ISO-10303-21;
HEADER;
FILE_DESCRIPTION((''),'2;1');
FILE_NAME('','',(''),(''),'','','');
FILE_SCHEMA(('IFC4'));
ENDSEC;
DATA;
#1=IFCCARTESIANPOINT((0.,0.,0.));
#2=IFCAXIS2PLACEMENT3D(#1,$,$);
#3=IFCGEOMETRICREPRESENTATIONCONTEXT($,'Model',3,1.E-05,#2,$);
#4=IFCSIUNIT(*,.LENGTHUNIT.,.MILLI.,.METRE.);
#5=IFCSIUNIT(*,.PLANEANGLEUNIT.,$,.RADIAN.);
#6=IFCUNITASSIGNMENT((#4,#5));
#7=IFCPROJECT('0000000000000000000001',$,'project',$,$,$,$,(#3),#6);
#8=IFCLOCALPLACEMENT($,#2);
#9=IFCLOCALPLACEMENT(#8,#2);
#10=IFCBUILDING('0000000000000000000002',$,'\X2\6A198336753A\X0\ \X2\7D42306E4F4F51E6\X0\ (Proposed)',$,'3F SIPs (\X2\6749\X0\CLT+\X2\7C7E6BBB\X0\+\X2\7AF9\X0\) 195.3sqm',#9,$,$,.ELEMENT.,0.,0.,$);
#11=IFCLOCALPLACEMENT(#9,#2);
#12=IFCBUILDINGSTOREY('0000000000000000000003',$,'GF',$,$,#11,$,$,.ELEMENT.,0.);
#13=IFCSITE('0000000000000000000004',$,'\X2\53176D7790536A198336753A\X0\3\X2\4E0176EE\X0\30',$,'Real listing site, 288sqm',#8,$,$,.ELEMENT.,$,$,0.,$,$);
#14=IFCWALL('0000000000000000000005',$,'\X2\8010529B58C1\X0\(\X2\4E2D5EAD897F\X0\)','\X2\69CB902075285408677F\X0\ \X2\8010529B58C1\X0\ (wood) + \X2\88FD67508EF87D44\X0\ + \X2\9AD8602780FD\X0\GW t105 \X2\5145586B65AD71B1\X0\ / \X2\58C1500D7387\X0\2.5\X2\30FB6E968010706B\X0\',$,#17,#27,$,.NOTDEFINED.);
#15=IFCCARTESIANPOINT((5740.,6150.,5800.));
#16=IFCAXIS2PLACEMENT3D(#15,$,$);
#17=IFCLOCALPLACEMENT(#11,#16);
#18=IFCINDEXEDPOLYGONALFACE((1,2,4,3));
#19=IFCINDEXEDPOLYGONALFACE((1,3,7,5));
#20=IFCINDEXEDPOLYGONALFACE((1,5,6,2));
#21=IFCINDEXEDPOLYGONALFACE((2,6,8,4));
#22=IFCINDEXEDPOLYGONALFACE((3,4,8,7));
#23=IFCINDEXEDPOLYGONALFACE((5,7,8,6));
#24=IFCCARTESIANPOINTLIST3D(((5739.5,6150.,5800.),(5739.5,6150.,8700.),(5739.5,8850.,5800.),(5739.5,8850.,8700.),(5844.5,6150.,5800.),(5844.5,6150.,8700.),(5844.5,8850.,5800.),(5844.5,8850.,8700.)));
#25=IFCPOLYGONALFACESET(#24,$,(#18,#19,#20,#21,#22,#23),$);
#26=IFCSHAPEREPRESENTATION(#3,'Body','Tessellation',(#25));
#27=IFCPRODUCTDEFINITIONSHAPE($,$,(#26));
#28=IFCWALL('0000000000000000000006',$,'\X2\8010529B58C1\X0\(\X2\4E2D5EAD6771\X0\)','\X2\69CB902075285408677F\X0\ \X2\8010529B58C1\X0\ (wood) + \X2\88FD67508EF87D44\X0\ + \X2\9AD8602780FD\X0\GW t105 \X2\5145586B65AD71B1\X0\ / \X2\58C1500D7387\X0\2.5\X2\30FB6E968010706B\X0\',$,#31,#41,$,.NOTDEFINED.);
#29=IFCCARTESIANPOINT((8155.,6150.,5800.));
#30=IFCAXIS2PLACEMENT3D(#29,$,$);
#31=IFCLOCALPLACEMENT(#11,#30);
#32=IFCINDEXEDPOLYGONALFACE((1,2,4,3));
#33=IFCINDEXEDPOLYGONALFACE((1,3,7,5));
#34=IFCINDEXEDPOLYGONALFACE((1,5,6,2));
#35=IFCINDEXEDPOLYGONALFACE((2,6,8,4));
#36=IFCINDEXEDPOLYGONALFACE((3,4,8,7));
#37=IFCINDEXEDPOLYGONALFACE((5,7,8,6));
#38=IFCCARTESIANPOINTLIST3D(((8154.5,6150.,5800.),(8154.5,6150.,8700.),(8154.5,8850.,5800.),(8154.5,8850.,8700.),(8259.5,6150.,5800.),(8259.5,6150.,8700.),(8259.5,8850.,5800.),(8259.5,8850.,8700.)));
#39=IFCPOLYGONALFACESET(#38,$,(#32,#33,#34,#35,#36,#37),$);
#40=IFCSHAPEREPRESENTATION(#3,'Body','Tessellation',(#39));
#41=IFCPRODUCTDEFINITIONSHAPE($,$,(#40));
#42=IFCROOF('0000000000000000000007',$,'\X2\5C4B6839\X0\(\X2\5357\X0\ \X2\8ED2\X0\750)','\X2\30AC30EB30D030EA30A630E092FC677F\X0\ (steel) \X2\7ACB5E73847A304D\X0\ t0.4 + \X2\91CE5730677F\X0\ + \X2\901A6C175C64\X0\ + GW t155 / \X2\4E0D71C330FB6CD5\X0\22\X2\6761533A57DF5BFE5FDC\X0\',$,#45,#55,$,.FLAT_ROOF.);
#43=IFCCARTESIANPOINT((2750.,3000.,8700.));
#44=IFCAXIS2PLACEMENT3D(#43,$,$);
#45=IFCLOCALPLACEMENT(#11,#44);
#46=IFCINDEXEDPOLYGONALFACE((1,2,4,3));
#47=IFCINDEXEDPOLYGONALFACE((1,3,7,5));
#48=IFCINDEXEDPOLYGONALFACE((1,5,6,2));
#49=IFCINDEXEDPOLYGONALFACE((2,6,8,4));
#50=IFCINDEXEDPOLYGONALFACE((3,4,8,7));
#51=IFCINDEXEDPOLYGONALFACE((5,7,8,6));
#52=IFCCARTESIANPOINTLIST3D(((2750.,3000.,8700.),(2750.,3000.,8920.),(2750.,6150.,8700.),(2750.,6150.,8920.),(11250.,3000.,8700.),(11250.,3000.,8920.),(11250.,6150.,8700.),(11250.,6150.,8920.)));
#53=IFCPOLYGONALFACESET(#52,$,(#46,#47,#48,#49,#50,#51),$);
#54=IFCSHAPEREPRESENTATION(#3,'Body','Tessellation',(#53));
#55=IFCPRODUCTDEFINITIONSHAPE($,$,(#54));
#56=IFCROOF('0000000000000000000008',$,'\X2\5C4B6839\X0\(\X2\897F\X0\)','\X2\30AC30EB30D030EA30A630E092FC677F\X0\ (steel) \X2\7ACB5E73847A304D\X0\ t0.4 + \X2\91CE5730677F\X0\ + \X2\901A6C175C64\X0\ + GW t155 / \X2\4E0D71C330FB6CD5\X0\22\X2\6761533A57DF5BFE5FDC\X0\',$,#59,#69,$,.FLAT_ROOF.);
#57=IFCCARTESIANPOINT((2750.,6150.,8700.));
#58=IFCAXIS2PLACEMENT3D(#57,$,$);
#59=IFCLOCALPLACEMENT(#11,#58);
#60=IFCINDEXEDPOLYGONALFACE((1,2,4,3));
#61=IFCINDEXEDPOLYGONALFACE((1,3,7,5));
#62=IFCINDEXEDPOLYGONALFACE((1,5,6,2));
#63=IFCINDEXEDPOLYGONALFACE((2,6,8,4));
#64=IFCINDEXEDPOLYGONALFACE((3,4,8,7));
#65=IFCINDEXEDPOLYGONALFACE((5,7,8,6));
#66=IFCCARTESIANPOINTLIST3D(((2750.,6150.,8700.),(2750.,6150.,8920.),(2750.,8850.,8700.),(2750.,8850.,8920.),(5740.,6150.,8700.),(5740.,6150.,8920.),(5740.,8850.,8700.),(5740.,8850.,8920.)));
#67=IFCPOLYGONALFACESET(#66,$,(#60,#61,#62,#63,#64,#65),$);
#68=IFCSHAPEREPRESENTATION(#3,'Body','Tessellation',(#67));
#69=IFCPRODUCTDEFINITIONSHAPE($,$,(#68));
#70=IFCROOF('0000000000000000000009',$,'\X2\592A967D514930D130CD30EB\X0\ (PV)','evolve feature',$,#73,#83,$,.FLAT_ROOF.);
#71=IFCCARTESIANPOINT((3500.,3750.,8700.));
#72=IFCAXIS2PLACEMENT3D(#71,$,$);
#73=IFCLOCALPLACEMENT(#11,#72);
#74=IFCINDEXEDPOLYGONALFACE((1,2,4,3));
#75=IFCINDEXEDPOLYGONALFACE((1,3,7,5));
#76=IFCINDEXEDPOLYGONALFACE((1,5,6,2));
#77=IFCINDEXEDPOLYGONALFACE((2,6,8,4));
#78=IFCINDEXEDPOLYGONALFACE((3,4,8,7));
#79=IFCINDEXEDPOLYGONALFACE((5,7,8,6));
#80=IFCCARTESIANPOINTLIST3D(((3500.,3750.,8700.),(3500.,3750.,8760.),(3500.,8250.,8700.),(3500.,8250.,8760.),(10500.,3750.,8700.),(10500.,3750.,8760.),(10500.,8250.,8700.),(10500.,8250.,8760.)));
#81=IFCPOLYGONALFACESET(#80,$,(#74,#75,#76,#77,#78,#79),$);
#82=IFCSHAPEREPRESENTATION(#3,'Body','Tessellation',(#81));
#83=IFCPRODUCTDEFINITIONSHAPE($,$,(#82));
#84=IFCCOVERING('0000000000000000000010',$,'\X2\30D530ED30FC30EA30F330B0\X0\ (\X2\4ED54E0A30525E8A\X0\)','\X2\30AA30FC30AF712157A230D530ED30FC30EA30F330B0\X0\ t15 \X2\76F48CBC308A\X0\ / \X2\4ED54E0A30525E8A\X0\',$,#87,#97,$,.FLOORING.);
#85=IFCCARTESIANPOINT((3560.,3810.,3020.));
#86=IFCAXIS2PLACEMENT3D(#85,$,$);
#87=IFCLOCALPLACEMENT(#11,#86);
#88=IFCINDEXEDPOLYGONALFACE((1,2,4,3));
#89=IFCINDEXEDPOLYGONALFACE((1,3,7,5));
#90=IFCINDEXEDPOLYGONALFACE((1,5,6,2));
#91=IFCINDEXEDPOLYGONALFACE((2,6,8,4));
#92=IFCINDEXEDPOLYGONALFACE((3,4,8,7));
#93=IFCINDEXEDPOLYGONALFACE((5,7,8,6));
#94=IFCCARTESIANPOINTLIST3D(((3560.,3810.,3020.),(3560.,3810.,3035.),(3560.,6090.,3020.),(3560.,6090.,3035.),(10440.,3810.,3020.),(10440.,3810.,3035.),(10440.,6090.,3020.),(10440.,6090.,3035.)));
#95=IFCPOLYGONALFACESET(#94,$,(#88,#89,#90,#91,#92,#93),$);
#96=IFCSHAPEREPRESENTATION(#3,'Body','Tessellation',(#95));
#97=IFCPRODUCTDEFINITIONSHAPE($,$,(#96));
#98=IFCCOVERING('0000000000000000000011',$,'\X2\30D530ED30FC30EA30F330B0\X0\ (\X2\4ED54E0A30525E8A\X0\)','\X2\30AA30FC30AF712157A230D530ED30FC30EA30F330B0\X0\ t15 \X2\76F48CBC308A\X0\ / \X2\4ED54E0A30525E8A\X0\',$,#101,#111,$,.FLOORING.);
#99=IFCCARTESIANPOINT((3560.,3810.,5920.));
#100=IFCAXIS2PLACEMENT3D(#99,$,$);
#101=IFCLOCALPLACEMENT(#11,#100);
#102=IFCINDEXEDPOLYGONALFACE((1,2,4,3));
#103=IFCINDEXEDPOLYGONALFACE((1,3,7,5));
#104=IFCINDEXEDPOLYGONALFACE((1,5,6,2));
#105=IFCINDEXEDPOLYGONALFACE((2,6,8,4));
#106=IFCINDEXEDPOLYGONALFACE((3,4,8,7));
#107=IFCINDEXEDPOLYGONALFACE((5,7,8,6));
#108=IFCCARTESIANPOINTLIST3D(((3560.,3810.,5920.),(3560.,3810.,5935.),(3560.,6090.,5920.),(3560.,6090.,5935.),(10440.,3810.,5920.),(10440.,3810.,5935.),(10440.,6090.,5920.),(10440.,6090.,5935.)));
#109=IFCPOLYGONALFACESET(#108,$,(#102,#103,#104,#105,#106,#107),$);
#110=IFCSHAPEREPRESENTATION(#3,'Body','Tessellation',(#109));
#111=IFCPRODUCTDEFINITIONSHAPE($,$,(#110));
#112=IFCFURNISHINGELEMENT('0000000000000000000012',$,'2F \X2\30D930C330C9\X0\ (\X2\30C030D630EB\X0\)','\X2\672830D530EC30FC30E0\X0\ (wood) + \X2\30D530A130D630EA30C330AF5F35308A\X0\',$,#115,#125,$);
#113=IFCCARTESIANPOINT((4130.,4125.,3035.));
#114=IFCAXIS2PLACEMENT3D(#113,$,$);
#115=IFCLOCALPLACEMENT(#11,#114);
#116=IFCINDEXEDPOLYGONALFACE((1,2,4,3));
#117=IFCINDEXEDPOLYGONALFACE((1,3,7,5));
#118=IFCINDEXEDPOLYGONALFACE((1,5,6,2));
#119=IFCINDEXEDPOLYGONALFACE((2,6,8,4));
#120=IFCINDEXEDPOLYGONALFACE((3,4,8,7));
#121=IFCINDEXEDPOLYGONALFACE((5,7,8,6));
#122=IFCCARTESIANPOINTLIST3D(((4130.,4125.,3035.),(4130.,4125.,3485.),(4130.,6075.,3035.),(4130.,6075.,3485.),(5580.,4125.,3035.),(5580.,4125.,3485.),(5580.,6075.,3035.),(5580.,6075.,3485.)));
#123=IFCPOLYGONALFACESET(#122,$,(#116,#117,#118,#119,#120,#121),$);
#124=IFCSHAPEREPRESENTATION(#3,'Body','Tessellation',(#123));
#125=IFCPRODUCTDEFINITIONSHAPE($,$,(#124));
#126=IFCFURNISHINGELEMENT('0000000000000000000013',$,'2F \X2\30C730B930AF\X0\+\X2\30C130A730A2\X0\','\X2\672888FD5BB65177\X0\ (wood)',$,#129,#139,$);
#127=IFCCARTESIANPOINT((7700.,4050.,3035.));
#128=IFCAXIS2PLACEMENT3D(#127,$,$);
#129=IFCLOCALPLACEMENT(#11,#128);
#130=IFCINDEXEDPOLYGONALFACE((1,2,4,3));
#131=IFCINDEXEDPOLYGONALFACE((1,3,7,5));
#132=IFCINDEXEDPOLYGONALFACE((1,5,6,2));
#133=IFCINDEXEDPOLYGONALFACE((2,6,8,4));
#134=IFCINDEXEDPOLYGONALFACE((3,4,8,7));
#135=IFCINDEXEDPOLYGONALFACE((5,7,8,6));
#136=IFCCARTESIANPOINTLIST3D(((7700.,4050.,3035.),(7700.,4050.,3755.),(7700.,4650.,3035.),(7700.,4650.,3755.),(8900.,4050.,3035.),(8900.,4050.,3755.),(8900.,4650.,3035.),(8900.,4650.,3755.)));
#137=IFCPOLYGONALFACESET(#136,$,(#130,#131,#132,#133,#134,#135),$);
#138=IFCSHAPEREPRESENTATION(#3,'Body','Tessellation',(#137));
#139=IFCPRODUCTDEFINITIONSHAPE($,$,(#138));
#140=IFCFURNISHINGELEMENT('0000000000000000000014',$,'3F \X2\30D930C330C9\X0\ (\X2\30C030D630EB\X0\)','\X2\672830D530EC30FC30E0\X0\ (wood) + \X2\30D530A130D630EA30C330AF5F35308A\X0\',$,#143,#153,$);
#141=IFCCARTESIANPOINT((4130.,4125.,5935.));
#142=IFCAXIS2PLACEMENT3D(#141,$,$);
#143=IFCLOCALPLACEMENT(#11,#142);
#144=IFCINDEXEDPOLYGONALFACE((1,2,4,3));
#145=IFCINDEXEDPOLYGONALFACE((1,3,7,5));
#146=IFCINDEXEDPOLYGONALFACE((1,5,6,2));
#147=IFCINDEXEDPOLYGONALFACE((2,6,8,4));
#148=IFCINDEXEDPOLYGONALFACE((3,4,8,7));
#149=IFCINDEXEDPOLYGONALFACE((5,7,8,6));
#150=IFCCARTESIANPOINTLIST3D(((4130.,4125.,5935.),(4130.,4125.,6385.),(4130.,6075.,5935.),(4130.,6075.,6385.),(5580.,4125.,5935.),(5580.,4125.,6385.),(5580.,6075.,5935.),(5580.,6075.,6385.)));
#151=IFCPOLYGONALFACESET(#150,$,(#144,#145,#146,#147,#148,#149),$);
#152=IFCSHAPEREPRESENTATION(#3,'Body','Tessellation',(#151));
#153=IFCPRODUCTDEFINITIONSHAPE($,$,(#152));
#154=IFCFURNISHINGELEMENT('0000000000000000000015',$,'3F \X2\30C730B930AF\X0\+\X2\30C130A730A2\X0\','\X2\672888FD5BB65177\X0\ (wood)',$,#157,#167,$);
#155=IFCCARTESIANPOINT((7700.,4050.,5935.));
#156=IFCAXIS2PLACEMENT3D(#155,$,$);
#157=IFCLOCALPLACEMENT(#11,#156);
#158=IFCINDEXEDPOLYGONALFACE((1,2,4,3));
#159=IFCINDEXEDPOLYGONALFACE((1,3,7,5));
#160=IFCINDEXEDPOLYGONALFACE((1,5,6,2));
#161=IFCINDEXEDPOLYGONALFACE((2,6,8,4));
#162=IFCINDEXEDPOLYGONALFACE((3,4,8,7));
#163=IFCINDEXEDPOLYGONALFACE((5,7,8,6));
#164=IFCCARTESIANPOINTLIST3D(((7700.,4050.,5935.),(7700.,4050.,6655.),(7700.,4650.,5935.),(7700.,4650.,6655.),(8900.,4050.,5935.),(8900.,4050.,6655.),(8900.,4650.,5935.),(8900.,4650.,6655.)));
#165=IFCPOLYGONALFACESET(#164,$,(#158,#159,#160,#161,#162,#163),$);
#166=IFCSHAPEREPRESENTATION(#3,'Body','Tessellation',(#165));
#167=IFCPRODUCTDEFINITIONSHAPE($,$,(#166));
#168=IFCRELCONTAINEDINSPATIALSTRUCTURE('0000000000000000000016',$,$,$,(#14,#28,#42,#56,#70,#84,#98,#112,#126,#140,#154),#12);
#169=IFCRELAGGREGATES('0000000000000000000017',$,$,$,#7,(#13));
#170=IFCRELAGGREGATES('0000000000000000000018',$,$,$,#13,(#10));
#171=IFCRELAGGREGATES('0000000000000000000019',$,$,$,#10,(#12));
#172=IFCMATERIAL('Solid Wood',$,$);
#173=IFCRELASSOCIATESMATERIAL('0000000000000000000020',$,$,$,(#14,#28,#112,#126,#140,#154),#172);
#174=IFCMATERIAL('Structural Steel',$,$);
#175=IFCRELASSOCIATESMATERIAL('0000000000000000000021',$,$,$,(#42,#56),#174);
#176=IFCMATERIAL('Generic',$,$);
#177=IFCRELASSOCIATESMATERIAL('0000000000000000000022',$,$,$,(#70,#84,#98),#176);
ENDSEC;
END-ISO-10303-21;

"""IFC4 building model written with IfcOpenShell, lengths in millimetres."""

from ifc_helpers import new_model, si_unit, frame, frame_2d, origin, place, context, project, spatial, rectangle, extrude, material, element, save


model = new_model("IFC4")

# Units and contexts
model_context = context("Model", 3, precision=1e-05, world=origin())
ifc_project = project(units=[si_unit("LENGTHUNIT", "METRE", prefix="MILLI"), si_unit("PLANEANGLEUNIT", "RADIAN")], contexts=[model_context])

# Site, building, storey
site_placement = place(None, origin())
site = spatial("IfcSite", under=ifc_project, at=site_placement, Name="北海道標茶町3丁目30", ObjectType="Real listing site, 288sqm", CompositionType="ELEMENT", RefElevation=0.0)
building_placement = place(site_placement, origin())
building = spatial("IfcBuilding", under=site, at=building_placement, Name="標茶町 終の住処 (Proposed)", ObjectType="3F SIPs (杉CLT+籾殻+竹) 195.3sqm", CompositionType="ELEMENT", ElevationOfRefHeight=0.0, ElevationOfTerrain=0.0)
storey_placement = place(building_placement, origin())
storey = spatial("IfcBuildingStorey", under=building, at=storey_placement, Name="GF", CompositionType="ELEMENT", Elevation=0.0)

# Shared definitions
ifc_material_1 = material(Name="Solid Wood")

# Walls
wall_1_placement = place(storey_placement, frame((5740.0, 6150.0, 5800.0)))
element("IfcWall", 1, at=wall_1_placement, inside=storey, material=ifc_material_1, Name="耐力壁(中庭西)", Description="構造用合板 耐力壁 (wood) + 製材軸組 + 高性能GW t105 充填断熱 / 壁倍率2.5・準耐火", PredefinedType="NOTDEFINED", context=model_context, shape_type="SweptSolid", body=[
    extrude(rectangle(XDim=105.0, YDim=2700.0, at=frame_2d((52.0, 1350.0))), frame((5740.0, 6150.0, 5800.0)), (0.0, 0.0, 1.0), 2900.0),
])
wall_2_placement = place(storey_placement, frame((8155.0, 6150.0, 5800.0)))
element("IfcWall", 2, at=wall_2_placement, inside=storey, material=ifc_material_1, Name="耐力壁(中庭東)", Description="構造用合板 耐力壁 (wood) + 製材軸組 + 高性能GW t105 充填断熱 / 壁倍率2.5・準耐火", PredefinedType="NOTDEFINED", context=model_context, shape_type="SweptSolid", body=[
    extrude(rectangle(XDim=105.0, YDim=2700.0, at=frame_2d((52.0, 1350.0))), frame((8155.0, 6150.0, 5800.0)), (0.0, 0.0, 1.0), 2900.0),
])

# Roofs
ifc_material_2 = material(Name="Structural Steel")
roof_1_placement = place(storey_placement, frame((2750.0, 3000.0, 8700.0)))
element("IfcRoof", 3, at=roof_1_placement, inside=storey, material=ifc_material_2, Name="屋根(南 軒750)", Description="ガルバリウム鋼板 (steel) 立平葺き t0.4 + 野地板 + 通気層 + GW t155 / 不燃・法22条区域対応", PredefinedType="FLAT_ROOF", context=model_context, shape_type="SweptSolid", body=[
    extrude(rectangle(XDim=8500.0, YDim=3150.0, at=frame_2d((4250.0, 1575.0))), frame((2750.0, 3000.0, 8700.0)), (0.0, 0.0, 1.0), 220.0),
])
roof_2_placement = place(storey_placement, frame((2750.0, 6150.0, 8700.0)))
element("IfcRoof", 4, at=roof_2_placement, inside=storey, material=ifc_material_2, Name="屋根(西)", Description="ガルバリウム鋼板 (steel) 立平葺き t0.4 + 野地板 + 通気層 + GW t155 / 不燃・法22条区域対応", PredefinedType="FLAT_ROOF", context=model_context, shape_type="SweptSolid", body=[
    extrude(rectangle(XDim=2990.0, YDim=2700.0, at=frame_2d((1495.0, 1350.0))), frame((2750.0, 6150.0, 8700.0)), (0.0, 0.0, 1.0), 220.0),
])
ifc_material_3 = material(Name="Generic")
roof_3_placement = place(storey_placement, frame((3500.0, 3750.0, 8700.0)))
element("IfcRoof", 5, at=roof_3_placement, inside=storey, material=ifc_material_3, Name="太陽光パネル (PV)", Description="evolve feature", PredefinedType="FLAT_ROOF", context=model_context, shape_type="SweptSolid", body=[
    extrude(rectangle(XDim=7000.0, YDim=4500.0, at=frame_2d((3500.0, 2250.0))), frame((3500.0, 3750.0, 8700.0)), (0.0, 0.0, 1.0), 60.0),
])

# Coverings
covering_1_placement = place(storey_placement, frame((3560.0, 3810.0, 3020.0)))
element("IfcCovering", 6, at=covering_1_placement, inside=storey, material=ifc_material_3, Name="フローリング (仕上げ床)", Description="オーク無垢フローリング t15 直貼り / 仕上げ床", PredefinedType="FLOORING", context=model_context, shape_type="SweptSolid", body=[
    extrude(rectangle(XDim=6880.0, YDim=2280.0, at=frame_2d((3440.0, 1140.0))), frame((3560.0, 3810.0, 3020.0)), (0.0, 0.0, 1.0), 15.0),
])
covering_2_placement = place(storey_placement, frame((3560.0, 3810.0, 5920.0)))
element("IfcCovering", 7, at=covering_2_placement, inside=storey, material=ifc_material_3, Name="フローリング (仕上げ床)", Description="オーク無垢フローリング t15 直貼り / 仕上げ床", PredefinedType="FLOORING", context=model_context, shape_type="SweptSolid", body=[
    extrude(rectangle(XDim=6880.0, YDim=2280.0, at=frame_2d((3440.0, 1140.0))), frame((3560.0, 3810.0, 5920.0)), (0.0, 0.0, 1.0), 15.0),
])

# Furnishing elements
furnishing_1_placement = place(storey_placement, frame((4130.0, 4125.0, 3035.0)))
element("IfcFurnishingElement", 8, at=furnishing_1_placement, inside=storey, material=ifc_material_1, Name="2F ベッド (ダブル)", Description="木フレーム (wood) + ファブリック張り", context=model_context, shape_type="SweptSolid", body=[
    extrude(rectangle(XDim=1450.0, YDim=1950.0, at=frame_2d((725.0, 975.0))), frame((4130.0, 4125.0, 3035.0)), (0.0, 0.0, 1.0), 450.0),
])
furnishing_2_placement = place(storey_placement, frame((7700.0, 4050.0, 3035.0)))
element("IfcFurnishingElement", 9, at=furnishing_2_placement, inside=storey, material=ifc_material_1, Name="2F デスク+チェア", Description="木製家具 (wood)", context=model_context, shape_type="SweptSolid", body=[
    extrude(rectangle(XDim=1200.0, YDim=600.0, at=frame_2d((600.0, 300.0))), frame((7700.0, 4050.0, 3035.0)), (0.0, 0.0, 1.0), 720.0),
])
furnishing_3_placement = place(storey_placement, frame((4130.0, 4125.0, 5935.0)))
element("IfcFurnishingElement", 10, at=furnishing_3_placement, inside=storey, material=ifc_material_1, Name="3F ベッド (ダブル)", Description="木フレーム (wood) + ファブリック張り", context=model_context, shape_type="SweptSolid", body=[
    extrude(rectangle(XDim=1450.0, YDim=1950.0, at=frame_2d((725.0, 975.0))), frame((4130.0, 4125.0, 5935.0)), (0.0, 0.0, 1.0), 450.0),
])
furnishing_4_placement = place(storey_placement, frame((7700.0, 4050.0, 5935.0)))
element("IfcFurnishingElement", 11, at=furnishing_4_placement, inside=storey, material=ifc_material_1, Name="3F デスク+チェア", Description="木製家具 (wood)", context=model_context, shape_type="SweptSolid", body=[
    extrude(rectangle(XDim=1200.0, YDim=600.0, at=frame_2d((600.0, 300.0))), frame((7700.0, 4050.0, 5935.0)), (0.0, 0.0, 1.0), 720.0),
])

save(model, "model.ifc")
